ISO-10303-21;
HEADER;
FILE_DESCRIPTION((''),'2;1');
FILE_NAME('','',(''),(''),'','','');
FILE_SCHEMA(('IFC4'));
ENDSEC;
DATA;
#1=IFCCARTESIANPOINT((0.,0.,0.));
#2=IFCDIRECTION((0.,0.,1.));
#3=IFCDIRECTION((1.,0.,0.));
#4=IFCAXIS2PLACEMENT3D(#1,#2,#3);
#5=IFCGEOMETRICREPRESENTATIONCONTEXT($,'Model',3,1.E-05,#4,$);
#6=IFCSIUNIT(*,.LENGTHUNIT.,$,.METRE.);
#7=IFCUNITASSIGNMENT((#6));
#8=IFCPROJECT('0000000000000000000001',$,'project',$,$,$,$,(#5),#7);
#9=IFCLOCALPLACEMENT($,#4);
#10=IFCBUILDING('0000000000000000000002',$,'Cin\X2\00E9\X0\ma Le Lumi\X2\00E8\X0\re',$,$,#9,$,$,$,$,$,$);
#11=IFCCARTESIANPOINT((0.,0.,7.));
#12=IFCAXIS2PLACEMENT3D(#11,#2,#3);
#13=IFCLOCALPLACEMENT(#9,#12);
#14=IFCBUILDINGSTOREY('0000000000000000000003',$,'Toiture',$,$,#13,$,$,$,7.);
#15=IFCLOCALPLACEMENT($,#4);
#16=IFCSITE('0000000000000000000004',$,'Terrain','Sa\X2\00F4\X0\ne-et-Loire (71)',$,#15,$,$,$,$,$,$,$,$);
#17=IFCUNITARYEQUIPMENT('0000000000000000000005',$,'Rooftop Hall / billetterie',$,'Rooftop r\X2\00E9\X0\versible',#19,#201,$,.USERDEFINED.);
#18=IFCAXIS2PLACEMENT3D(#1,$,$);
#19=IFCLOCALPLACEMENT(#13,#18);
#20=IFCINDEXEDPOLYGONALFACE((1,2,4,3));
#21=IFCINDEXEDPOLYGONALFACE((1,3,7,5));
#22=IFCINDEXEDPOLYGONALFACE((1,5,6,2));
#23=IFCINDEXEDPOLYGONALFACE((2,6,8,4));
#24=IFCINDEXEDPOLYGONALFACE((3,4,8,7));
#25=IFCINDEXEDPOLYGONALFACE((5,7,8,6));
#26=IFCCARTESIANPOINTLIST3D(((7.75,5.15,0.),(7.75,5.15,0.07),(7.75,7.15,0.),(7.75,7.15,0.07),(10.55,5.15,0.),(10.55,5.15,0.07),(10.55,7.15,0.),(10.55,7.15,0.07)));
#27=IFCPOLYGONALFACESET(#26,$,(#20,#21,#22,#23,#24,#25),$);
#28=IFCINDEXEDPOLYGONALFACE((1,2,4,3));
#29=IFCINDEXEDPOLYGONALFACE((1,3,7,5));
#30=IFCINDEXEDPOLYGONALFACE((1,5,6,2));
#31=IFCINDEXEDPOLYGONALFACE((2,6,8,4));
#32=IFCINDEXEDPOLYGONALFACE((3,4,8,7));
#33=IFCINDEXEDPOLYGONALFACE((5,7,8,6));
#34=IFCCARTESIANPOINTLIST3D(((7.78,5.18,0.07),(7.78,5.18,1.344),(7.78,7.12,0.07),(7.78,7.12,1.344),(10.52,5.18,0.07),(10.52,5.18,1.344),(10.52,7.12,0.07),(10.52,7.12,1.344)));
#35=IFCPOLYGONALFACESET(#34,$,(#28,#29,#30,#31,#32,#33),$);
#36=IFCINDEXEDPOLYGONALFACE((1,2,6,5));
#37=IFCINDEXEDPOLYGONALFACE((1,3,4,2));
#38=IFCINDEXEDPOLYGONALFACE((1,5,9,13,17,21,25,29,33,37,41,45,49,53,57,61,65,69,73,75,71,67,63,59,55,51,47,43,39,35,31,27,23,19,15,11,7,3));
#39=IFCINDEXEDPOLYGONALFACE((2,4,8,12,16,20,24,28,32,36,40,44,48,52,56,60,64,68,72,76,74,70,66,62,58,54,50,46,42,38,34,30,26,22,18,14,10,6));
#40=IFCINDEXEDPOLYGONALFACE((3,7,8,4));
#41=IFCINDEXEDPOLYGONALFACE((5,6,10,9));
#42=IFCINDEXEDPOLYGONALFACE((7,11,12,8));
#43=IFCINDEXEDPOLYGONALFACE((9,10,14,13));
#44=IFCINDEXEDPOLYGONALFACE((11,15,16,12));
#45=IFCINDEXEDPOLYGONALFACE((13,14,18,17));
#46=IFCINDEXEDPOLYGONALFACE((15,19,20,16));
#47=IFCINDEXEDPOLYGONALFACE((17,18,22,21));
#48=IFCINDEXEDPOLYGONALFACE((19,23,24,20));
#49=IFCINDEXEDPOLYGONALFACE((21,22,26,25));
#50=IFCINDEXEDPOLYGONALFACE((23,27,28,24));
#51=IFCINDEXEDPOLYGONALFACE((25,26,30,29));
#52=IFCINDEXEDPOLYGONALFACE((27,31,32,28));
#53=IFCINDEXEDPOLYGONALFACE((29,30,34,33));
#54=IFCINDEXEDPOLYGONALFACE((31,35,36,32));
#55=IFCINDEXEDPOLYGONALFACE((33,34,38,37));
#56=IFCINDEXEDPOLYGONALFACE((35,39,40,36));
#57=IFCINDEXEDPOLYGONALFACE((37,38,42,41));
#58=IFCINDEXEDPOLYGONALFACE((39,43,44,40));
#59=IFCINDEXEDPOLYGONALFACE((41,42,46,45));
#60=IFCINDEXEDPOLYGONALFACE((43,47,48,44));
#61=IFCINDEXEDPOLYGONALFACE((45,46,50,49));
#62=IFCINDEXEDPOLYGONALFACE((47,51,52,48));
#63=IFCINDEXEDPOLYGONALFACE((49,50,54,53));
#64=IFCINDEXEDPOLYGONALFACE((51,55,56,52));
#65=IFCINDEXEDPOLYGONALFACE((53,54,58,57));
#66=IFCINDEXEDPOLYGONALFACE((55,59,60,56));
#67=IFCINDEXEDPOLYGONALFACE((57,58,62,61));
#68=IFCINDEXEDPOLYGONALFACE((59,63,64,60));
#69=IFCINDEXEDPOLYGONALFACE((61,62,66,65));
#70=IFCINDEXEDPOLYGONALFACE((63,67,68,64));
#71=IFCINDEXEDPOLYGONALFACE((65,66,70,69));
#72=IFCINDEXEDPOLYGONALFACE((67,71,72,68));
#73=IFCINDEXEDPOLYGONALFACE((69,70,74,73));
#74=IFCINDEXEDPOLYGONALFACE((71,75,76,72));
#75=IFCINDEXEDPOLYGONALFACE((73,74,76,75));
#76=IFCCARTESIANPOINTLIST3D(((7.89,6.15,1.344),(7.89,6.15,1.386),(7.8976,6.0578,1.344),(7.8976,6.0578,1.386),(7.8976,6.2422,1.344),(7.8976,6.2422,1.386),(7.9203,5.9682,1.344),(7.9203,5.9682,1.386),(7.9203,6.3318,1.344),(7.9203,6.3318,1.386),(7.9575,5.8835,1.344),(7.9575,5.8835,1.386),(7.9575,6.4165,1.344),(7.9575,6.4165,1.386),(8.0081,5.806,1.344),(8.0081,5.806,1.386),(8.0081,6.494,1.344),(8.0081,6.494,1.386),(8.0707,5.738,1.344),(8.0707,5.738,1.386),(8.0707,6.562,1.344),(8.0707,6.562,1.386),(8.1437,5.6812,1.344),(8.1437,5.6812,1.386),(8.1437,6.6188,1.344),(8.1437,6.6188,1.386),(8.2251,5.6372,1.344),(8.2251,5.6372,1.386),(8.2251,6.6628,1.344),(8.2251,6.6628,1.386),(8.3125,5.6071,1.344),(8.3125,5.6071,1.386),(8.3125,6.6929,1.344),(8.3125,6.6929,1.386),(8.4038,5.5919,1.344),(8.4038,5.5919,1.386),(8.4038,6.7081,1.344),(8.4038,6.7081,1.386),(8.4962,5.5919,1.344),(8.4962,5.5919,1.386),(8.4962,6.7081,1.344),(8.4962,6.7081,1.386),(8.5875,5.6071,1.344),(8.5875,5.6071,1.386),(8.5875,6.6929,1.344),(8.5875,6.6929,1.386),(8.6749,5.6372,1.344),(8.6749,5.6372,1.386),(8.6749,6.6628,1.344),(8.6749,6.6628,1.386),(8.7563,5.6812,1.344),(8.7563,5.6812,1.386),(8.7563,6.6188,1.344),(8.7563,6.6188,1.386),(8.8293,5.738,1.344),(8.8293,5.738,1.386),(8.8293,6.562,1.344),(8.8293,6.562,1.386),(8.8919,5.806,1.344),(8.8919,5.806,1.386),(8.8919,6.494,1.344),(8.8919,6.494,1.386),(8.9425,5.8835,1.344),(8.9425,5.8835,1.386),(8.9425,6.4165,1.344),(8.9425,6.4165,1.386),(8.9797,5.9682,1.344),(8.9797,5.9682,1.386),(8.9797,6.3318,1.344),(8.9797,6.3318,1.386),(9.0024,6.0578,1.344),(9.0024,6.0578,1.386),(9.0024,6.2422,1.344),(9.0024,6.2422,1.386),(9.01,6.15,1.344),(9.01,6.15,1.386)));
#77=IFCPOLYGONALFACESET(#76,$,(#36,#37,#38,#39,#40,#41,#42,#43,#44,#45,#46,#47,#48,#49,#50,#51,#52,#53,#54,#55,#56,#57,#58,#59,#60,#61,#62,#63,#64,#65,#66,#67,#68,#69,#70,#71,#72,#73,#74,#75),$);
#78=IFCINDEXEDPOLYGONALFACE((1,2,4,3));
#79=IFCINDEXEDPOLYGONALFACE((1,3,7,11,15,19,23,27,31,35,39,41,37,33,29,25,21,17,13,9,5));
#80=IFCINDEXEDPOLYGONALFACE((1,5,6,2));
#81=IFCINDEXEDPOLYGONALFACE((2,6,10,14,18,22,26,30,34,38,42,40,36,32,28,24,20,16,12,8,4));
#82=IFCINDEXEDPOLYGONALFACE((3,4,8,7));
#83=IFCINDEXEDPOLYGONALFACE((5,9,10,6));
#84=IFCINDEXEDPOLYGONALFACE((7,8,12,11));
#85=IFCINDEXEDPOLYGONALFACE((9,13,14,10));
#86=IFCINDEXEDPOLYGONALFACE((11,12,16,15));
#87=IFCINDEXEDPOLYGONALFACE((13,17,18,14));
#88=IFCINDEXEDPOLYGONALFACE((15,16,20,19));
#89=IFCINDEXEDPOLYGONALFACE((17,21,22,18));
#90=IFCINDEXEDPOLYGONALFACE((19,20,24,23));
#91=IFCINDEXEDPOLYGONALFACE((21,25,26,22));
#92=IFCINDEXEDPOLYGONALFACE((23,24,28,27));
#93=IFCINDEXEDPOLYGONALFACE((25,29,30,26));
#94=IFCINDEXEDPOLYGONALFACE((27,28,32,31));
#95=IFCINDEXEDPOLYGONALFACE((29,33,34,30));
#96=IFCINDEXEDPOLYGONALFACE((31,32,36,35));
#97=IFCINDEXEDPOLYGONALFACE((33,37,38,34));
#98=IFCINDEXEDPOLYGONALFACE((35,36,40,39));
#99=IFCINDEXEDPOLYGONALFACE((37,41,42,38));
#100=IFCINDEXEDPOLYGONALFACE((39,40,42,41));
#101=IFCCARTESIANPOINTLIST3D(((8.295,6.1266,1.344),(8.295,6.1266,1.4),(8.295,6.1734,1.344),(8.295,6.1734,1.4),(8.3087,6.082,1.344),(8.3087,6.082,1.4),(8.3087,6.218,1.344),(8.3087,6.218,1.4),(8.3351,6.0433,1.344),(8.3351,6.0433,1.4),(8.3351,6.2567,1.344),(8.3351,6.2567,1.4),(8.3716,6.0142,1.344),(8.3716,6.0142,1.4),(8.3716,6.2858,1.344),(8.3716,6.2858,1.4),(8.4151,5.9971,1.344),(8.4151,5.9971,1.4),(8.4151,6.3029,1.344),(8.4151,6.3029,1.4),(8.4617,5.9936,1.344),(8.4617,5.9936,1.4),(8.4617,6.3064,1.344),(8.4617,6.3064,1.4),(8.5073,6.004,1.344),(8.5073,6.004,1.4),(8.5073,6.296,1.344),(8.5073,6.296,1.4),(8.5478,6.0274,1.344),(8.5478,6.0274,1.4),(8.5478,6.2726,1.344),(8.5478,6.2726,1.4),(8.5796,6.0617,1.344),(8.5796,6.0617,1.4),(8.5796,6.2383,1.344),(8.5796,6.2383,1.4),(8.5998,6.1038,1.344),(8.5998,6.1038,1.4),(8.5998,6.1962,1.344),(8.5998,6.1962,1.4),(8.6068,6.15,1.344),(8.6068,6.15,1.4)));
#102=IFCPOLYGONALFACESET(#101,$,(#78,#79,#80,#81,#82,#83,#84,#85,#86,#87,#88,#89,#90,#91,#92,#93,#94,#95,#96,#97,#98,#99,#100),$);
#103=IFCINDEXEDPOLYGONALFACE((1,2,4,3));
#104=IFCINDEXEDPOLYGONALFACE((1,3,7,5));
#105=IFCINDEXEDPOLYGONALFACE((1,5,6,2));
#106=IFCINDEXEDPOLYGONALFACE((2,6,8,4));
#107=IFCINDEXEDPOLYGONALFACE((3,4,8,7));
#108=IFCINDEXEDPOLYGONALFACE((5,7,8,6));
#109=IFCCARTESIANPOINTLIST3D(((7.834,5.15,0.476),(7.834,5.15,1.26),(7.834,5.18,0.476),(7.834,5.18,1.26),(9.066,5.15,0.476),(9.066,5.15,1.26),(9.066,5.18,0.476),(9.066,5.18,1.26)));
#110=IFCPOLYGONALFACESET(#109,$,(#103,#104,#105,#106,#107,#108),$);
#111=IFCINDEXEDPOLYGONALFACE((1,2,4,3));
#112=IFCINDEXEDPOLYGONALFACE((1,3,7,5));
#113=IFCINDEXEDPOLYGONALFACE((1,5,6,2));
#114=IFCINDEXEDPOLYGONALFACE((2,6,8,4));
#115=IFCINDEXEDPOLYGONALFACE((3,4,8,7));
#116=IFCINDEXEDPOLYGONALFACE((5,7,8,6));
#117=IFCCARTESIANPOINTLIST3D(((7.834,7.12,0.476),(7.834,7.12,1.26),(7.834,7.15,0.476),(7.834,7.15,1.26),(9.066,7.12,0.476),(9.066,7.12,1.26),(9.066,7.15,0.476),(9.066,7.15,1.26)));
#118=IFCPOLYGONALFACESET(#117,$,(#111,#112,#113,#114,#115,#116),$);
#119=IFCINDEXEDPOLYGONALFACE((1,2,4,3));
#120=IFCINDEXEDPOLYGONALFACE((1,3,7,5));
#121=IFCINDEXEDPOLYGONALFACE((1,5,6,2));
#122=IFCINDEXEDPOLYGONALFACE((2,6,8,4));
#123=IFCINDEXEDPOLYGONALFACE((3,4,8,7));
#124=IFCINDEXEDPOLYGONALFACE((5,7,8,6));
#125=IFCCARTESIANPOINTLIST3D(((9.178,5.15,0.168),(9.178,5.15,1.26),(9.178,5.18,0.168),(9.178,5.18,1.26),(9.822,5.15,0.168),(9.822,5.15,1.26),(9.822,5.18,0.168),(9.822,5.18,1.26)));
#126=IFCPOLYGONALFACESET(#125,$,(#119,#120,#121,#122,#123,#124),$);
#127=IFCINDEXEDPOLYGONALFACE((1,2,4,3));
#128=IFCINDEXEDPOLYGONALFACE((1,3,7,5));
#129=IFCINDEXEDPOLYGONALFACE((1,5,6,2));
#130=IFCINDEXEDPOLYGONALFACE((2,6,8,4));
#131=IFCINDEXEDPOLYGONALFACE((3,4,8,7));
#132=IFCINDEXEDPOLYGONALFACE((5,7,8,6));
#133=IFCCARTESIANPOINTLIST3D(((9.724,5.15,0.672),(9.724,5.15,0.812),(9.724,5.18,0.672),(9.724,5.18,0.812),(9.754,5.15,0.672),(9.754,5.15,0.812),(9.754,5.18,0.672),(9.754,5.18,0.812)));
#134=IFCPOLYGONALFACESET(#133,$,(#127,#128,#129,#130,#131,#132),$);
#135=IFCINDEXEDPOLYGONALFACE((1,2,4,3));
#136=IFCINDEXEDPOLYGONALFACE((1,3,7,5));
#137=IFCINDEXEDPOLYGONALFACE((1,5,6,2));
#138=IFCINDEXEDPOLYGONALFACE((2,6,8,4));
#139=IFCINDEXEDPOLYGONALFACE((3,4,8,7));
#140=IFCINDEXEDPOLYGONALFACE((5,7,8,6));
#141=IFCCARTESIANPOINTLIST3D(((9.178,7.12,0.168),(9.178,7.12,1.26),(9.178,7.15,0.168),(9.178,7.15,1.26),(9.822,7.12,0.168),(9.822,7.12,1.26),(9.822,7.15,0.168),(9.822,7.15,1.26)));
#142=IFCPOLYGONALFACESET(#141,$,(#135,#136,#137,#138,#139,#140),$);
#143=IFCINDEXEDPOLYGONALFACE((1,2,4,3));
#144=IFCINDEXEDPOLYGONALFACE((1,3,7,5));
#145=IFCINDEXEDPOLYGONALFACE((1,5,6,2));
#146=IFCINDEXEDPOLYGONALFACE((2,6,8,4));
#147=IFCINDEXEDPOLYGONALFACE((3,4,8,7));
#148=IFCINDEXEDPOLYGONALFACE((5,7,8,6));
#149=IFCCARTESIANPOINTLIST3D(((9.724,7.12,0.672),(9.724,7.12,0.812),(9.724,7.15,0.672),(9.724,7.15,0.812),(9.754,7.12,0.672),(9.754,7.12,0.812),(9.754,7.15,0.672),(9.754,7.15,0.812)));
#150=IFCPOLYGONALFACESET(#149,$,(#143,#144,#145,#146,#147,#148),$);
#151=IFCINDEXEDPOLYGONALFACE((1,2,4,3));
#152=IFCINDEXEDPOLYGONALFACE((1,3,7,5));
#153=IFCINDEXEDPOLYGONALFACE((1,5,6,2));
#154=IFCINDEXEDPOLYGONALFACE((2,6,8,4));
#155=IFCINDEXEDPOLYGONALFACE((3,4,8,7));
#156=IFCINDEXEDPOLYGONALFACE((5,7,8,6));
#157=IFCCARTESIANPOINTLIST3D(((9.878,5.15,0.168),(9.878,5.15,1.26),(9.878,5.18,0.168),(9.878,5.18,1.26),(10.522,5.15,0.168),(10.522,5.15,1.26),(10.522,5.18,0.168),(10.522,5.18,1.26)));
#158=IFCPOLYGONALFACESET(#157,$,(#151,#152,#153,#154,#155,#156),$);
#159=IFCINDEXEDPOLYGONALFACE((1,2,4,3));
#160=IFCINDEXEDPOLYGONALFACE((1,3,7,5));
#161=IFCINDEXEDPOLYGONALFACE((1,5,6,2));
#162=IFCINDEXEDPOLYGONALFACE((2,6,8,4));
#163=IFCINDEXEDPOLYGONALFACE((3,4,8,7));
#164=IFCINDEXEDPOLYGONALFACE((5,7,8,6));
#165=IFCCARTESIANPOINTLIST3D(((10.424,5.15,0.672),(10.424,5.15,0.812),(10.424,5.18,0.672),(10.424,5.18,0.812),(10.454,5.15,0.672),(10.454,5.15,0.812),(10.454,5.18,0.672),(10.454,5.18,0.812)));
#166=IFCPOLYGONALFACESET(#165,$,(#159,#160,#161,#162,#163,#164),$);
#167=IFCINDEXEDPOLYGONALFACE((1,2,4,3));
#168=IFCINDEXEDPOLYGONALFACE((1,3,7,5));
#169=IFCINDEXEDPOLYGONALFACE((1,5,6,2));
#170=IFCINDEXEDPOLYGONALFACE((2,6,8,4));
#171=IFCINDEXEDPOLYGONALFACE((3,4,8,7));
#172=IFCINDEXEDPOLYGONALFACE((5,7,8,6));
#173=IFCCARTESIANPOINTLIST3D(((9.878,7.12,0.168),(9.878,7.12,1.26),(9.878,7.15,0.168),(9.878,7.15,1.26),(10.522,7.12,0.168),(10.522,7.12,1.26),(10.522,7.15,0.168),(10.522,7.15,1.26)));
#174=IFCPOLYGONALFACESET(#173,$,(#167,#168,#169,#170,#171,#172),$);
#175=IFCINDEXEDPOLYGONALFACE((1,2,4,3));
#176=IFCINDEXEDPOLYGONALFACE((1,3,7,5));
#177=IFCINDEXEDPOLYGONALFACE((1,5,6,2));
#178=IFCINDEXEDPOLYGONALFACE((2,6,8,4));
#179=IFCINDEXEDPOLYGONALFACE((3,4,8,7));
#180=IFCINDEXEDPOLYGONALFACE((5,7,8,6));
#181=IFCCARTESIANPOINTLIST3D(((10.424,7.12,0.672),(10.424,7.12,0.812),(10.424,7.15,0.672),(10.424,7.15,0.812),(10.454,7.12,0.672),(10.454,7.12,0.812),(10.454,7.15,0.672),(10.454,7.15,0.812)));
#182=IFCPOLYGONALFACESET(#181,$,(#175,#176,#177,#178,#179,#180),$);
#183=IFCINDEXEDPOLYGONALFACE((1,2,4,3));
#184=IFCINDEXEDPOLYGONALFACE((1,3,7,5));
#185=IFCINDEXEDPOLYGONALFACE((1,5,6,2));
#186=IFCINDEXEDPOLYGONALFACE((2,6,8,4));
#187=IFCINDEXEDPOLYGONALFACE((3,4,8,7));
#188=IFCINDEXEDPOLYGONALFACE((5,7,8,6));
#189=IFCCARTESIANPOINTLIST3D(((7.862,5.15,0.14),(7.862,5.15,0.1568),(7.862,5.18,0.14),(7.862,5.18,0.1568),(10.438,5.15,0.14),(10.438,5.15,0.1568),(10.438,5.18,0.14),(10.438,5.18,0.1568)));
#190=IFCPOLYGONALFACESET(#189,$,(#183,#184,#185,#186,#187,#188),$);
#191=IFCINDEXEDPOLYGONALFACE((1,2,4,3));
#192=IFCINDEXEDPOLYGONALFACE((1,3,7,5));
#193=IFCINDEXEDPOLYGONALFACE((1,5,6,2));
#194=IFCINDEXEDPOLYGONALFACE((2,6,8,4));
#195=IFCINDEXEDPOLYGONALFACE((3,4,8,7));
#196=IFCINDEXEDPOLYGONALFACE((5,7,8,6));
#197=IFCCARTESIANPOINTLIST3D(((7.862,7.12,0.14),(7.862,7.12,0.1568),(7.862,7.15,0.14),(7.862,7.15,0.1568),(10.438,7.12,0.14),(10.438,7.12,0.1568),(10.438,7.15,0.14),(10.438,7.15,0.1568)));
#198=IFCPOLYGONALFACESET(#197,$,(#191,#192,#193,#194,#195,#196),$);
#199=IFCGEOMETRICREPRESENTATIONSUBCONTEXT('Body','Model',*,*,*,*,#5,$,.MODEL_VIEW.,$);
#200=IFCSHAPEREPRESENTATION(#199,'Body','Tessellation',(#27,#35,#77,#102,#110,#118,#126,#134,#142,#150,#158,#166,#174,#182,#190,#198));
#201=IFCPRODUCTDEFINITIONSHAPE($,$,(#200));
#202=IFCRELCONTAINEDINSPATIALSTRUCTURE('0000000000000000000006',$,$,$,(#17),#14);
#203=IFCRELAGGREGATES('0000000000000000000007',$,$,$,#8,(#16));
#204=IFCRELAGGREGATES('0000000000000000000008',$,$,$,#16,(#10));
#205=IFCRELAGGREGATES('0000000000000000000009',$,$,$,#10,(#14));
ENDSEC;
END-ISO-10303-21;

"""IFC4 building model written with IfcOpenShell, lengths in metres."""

from ifc_helpers import new_model, si_unit, frame, frame_2d, origin_with_axes, place, context, subcontext, project, spatial, rectangle, circle, extrude, element, save


model = new_model("IFC4")

# Units and contexts
model_context = context("Model", 3, precision=1e-05, world=origin_with_axes())
body_context = subcontext(model_context, "Body", "Model", "MODEL_VIEW")
ifc_project = project(units=[si_unit("LENGTHUNIT", "METRE")], contexts=[model_context])

# Site, building, storey
site_placement = place(None, origin_with_axes())
site = spatial("IfcSite", under=ifc_project, at=site_placement, Name="Terrain", Description="Saône-et-Loire (71)")
building_placement = place(None, origin_with_axes())
building = spatial("IfcBuilding", under=site, at=building_placement, Name="Cinéma Le Lumière")
storey_placement = place(building_placement, frame((0.0, 0.0, 7.0), z_axis=(0.0, 0.0, 1.0), x_axis=(1.0, 0.0, 0.0)))
storey = spatial("IfcBuildingStorey", under=building, at=storey_placement, Name="Toiture", Elevation=7.0)

# Unitary equipment
unitary_equipment_1_placement = place(storey_placement, frame((7.75, 5.15, 0.0), z_axis=(0.0, 0.0, 1.0), x_axis=(1.0, 0.0, 0.0)))
element("IfcUnitaryEquipment", 1, at=unitary_equipment_1_placement, inside=storey, Name="Rooftop Hall / billetterie", ObjectType="Rooftop réversible", PredefinedType="USERDEFINED", context=body_context, shape_type="SweptSolid", body=[
    extrude(rectangle(XDim=2.8, YDim=2.0, at=frame_2d((1.4, 1.0))), origin_with_axes(), (0.0, 0.0, 1.0), 0.07),
    extrude(rectangle(XDim=2.74, YDim=1.94, at=frame_2d((1.37, 0.97))), frame((0.03, 0.03, 0.07), z_axis=(0.0, 0.0, 1.0), x_axis=(1.0, 0.0, 0.0)), (0.0, 0.0, 1.0), 1.274),
    extrude(circle(Radius=0.56), frame((0.7, 1.0, 1.344), z_axis=(0.0, 0.0, 1.0), x_axis=(1.0, 0.0, 0.0)), (0.0, 0.0, 1.0), 0.042),
    extrude(circle(Radius=0.1568), frame((0.7, 1.0, 1.344), z_axis=(0.0, 0.0, 1.0), x_axis=(1.0, 0.0, 0.0)), (0.0, 0.0, 1.0), 0.056),
    extrude(rectangle(XDim=1.232, YDim=0.03, at=frame_2d((0.616, 0.015))), frame((0.084, 0.0, 0.476), z_axis=(0.0, 0.0, 1.0), x_axis=(1.0, 0.0, 0.0)), (0.0, 0.0, 1.0), 0.784),
    extrude(rectangle(XDim=1.232, YDim=0.03, at=frame_2d((0.616, 0.015))), frame((0.084, 1.97, 0.476), z_axis=(0.0, 0.0, 1.0), x_axis=(1.0, 0.0, 0.0)), (0.0, 0.0, 1.0), 0.784),
    extrude(rectangle(XDim=0.644, YDim=0.03, at=frame_2d((0.322, 0.015))), frame((1.428, 0.0, 0.168), z_axis=(0.0, 0.0, 1.0), x_axis=(1.0, 0.0, 0.0)), (0.0, 0.0, 1.0), 1.092),
    extrude(rectangle(XDim=0.03, YDim=0.03, at=frame_2d((0.015, 0.015))), frame((1.974, 0.0, 0.672), z_axis=(0.0, 0.0, 1.0), x_axis=(1.0, 0.0, 0.0)), (0.0, 0.0, 1.0), 0.14),
    extrude(rectangle(XDim=0.644, YDim=0.03, at=frame_2d((0.322, 0.015))), frame((1.428, 1.97, 0.168), z_axis=(0.0, 0.0, 1.0), x_axis=(1.0, 0.0, 0.0)), (0.0, 0.0, 1.0), 1.092),
    extrude(rectangle(XDim=0.03, YDim=0.03, at=frame_2d((0.015, 0.015))), frame((1.974, 1.97, 0.672), z_axis=(0.0, 0.0, 1.0), x_axis=(1.0, 0.0, 0.0)), (0.0, 0.0, 1.0), 0.14),
    extrude(rectangle(XDim=0.644, YDim=0.03, at=frame_2d((0.322, 0.015))), frame((2.128, 0.0, 0.168), z_axis=(0.0, 0.0, 1.0), x_axis=(1.0, 0.0, 0.0)), (0.0, 0.0, 1.0), 1.092),
    extrude(rectangle(XDim=0.03, YDim=0.03, at=frame_2d((0.015, 0.015))), frame((2.674, 0.0, 0.672), z_axis=(0.0, 0.0, 1.0), x_axis=(1.0, 0.0, 0.0)), (0.0, 0.0, 1.0), 0.14),
    extrude(rectangle(XDim=0.644, YDim=0.03, at=frame_2d((0.322, 0.015))), frame((2.128, 1.97, 0.168), z_axis=(0.0, 0.0, 1.0), x_axis=(1.0, 0.0, 0.0)), (0.0, 0.0, 1.0), 1.092),
    extrude(rectangle(XDim=0.03, YDim=0.03, at=frame_2d((0.015, 0.015))), frame((2.674, 1.97, 0.672), z_axis=(0.0, 0.0, 1.0), x_axis=(1.0, 0.0, 0.0)), (0.0, 0.0, 1.0), 0.14),
    extrude(rectangle(XDim=2.576, YDim=0.03, at=frame_2d((1.288, 0.015))), frame((0.112, 0.0, 0.14), z_axis=(0.0, 0.0, 1.0), x_axis=(1.0, 0.0, 0.0)), (0.0, 0.0, 1.0), 0.0168),
    extrude(rectangle(XDim=2.576, YDim=0.03, at=frame_2d((1.288, 0.015))), frame((0.112, 1.97, 0.14), z_axis=(0.0, 0.0, 1.0), x_axis=(1.0, 0.0, 0.0)), (0.0, 0.0, 1.0), 0.0168),
])

save(model, "model.ifc")
